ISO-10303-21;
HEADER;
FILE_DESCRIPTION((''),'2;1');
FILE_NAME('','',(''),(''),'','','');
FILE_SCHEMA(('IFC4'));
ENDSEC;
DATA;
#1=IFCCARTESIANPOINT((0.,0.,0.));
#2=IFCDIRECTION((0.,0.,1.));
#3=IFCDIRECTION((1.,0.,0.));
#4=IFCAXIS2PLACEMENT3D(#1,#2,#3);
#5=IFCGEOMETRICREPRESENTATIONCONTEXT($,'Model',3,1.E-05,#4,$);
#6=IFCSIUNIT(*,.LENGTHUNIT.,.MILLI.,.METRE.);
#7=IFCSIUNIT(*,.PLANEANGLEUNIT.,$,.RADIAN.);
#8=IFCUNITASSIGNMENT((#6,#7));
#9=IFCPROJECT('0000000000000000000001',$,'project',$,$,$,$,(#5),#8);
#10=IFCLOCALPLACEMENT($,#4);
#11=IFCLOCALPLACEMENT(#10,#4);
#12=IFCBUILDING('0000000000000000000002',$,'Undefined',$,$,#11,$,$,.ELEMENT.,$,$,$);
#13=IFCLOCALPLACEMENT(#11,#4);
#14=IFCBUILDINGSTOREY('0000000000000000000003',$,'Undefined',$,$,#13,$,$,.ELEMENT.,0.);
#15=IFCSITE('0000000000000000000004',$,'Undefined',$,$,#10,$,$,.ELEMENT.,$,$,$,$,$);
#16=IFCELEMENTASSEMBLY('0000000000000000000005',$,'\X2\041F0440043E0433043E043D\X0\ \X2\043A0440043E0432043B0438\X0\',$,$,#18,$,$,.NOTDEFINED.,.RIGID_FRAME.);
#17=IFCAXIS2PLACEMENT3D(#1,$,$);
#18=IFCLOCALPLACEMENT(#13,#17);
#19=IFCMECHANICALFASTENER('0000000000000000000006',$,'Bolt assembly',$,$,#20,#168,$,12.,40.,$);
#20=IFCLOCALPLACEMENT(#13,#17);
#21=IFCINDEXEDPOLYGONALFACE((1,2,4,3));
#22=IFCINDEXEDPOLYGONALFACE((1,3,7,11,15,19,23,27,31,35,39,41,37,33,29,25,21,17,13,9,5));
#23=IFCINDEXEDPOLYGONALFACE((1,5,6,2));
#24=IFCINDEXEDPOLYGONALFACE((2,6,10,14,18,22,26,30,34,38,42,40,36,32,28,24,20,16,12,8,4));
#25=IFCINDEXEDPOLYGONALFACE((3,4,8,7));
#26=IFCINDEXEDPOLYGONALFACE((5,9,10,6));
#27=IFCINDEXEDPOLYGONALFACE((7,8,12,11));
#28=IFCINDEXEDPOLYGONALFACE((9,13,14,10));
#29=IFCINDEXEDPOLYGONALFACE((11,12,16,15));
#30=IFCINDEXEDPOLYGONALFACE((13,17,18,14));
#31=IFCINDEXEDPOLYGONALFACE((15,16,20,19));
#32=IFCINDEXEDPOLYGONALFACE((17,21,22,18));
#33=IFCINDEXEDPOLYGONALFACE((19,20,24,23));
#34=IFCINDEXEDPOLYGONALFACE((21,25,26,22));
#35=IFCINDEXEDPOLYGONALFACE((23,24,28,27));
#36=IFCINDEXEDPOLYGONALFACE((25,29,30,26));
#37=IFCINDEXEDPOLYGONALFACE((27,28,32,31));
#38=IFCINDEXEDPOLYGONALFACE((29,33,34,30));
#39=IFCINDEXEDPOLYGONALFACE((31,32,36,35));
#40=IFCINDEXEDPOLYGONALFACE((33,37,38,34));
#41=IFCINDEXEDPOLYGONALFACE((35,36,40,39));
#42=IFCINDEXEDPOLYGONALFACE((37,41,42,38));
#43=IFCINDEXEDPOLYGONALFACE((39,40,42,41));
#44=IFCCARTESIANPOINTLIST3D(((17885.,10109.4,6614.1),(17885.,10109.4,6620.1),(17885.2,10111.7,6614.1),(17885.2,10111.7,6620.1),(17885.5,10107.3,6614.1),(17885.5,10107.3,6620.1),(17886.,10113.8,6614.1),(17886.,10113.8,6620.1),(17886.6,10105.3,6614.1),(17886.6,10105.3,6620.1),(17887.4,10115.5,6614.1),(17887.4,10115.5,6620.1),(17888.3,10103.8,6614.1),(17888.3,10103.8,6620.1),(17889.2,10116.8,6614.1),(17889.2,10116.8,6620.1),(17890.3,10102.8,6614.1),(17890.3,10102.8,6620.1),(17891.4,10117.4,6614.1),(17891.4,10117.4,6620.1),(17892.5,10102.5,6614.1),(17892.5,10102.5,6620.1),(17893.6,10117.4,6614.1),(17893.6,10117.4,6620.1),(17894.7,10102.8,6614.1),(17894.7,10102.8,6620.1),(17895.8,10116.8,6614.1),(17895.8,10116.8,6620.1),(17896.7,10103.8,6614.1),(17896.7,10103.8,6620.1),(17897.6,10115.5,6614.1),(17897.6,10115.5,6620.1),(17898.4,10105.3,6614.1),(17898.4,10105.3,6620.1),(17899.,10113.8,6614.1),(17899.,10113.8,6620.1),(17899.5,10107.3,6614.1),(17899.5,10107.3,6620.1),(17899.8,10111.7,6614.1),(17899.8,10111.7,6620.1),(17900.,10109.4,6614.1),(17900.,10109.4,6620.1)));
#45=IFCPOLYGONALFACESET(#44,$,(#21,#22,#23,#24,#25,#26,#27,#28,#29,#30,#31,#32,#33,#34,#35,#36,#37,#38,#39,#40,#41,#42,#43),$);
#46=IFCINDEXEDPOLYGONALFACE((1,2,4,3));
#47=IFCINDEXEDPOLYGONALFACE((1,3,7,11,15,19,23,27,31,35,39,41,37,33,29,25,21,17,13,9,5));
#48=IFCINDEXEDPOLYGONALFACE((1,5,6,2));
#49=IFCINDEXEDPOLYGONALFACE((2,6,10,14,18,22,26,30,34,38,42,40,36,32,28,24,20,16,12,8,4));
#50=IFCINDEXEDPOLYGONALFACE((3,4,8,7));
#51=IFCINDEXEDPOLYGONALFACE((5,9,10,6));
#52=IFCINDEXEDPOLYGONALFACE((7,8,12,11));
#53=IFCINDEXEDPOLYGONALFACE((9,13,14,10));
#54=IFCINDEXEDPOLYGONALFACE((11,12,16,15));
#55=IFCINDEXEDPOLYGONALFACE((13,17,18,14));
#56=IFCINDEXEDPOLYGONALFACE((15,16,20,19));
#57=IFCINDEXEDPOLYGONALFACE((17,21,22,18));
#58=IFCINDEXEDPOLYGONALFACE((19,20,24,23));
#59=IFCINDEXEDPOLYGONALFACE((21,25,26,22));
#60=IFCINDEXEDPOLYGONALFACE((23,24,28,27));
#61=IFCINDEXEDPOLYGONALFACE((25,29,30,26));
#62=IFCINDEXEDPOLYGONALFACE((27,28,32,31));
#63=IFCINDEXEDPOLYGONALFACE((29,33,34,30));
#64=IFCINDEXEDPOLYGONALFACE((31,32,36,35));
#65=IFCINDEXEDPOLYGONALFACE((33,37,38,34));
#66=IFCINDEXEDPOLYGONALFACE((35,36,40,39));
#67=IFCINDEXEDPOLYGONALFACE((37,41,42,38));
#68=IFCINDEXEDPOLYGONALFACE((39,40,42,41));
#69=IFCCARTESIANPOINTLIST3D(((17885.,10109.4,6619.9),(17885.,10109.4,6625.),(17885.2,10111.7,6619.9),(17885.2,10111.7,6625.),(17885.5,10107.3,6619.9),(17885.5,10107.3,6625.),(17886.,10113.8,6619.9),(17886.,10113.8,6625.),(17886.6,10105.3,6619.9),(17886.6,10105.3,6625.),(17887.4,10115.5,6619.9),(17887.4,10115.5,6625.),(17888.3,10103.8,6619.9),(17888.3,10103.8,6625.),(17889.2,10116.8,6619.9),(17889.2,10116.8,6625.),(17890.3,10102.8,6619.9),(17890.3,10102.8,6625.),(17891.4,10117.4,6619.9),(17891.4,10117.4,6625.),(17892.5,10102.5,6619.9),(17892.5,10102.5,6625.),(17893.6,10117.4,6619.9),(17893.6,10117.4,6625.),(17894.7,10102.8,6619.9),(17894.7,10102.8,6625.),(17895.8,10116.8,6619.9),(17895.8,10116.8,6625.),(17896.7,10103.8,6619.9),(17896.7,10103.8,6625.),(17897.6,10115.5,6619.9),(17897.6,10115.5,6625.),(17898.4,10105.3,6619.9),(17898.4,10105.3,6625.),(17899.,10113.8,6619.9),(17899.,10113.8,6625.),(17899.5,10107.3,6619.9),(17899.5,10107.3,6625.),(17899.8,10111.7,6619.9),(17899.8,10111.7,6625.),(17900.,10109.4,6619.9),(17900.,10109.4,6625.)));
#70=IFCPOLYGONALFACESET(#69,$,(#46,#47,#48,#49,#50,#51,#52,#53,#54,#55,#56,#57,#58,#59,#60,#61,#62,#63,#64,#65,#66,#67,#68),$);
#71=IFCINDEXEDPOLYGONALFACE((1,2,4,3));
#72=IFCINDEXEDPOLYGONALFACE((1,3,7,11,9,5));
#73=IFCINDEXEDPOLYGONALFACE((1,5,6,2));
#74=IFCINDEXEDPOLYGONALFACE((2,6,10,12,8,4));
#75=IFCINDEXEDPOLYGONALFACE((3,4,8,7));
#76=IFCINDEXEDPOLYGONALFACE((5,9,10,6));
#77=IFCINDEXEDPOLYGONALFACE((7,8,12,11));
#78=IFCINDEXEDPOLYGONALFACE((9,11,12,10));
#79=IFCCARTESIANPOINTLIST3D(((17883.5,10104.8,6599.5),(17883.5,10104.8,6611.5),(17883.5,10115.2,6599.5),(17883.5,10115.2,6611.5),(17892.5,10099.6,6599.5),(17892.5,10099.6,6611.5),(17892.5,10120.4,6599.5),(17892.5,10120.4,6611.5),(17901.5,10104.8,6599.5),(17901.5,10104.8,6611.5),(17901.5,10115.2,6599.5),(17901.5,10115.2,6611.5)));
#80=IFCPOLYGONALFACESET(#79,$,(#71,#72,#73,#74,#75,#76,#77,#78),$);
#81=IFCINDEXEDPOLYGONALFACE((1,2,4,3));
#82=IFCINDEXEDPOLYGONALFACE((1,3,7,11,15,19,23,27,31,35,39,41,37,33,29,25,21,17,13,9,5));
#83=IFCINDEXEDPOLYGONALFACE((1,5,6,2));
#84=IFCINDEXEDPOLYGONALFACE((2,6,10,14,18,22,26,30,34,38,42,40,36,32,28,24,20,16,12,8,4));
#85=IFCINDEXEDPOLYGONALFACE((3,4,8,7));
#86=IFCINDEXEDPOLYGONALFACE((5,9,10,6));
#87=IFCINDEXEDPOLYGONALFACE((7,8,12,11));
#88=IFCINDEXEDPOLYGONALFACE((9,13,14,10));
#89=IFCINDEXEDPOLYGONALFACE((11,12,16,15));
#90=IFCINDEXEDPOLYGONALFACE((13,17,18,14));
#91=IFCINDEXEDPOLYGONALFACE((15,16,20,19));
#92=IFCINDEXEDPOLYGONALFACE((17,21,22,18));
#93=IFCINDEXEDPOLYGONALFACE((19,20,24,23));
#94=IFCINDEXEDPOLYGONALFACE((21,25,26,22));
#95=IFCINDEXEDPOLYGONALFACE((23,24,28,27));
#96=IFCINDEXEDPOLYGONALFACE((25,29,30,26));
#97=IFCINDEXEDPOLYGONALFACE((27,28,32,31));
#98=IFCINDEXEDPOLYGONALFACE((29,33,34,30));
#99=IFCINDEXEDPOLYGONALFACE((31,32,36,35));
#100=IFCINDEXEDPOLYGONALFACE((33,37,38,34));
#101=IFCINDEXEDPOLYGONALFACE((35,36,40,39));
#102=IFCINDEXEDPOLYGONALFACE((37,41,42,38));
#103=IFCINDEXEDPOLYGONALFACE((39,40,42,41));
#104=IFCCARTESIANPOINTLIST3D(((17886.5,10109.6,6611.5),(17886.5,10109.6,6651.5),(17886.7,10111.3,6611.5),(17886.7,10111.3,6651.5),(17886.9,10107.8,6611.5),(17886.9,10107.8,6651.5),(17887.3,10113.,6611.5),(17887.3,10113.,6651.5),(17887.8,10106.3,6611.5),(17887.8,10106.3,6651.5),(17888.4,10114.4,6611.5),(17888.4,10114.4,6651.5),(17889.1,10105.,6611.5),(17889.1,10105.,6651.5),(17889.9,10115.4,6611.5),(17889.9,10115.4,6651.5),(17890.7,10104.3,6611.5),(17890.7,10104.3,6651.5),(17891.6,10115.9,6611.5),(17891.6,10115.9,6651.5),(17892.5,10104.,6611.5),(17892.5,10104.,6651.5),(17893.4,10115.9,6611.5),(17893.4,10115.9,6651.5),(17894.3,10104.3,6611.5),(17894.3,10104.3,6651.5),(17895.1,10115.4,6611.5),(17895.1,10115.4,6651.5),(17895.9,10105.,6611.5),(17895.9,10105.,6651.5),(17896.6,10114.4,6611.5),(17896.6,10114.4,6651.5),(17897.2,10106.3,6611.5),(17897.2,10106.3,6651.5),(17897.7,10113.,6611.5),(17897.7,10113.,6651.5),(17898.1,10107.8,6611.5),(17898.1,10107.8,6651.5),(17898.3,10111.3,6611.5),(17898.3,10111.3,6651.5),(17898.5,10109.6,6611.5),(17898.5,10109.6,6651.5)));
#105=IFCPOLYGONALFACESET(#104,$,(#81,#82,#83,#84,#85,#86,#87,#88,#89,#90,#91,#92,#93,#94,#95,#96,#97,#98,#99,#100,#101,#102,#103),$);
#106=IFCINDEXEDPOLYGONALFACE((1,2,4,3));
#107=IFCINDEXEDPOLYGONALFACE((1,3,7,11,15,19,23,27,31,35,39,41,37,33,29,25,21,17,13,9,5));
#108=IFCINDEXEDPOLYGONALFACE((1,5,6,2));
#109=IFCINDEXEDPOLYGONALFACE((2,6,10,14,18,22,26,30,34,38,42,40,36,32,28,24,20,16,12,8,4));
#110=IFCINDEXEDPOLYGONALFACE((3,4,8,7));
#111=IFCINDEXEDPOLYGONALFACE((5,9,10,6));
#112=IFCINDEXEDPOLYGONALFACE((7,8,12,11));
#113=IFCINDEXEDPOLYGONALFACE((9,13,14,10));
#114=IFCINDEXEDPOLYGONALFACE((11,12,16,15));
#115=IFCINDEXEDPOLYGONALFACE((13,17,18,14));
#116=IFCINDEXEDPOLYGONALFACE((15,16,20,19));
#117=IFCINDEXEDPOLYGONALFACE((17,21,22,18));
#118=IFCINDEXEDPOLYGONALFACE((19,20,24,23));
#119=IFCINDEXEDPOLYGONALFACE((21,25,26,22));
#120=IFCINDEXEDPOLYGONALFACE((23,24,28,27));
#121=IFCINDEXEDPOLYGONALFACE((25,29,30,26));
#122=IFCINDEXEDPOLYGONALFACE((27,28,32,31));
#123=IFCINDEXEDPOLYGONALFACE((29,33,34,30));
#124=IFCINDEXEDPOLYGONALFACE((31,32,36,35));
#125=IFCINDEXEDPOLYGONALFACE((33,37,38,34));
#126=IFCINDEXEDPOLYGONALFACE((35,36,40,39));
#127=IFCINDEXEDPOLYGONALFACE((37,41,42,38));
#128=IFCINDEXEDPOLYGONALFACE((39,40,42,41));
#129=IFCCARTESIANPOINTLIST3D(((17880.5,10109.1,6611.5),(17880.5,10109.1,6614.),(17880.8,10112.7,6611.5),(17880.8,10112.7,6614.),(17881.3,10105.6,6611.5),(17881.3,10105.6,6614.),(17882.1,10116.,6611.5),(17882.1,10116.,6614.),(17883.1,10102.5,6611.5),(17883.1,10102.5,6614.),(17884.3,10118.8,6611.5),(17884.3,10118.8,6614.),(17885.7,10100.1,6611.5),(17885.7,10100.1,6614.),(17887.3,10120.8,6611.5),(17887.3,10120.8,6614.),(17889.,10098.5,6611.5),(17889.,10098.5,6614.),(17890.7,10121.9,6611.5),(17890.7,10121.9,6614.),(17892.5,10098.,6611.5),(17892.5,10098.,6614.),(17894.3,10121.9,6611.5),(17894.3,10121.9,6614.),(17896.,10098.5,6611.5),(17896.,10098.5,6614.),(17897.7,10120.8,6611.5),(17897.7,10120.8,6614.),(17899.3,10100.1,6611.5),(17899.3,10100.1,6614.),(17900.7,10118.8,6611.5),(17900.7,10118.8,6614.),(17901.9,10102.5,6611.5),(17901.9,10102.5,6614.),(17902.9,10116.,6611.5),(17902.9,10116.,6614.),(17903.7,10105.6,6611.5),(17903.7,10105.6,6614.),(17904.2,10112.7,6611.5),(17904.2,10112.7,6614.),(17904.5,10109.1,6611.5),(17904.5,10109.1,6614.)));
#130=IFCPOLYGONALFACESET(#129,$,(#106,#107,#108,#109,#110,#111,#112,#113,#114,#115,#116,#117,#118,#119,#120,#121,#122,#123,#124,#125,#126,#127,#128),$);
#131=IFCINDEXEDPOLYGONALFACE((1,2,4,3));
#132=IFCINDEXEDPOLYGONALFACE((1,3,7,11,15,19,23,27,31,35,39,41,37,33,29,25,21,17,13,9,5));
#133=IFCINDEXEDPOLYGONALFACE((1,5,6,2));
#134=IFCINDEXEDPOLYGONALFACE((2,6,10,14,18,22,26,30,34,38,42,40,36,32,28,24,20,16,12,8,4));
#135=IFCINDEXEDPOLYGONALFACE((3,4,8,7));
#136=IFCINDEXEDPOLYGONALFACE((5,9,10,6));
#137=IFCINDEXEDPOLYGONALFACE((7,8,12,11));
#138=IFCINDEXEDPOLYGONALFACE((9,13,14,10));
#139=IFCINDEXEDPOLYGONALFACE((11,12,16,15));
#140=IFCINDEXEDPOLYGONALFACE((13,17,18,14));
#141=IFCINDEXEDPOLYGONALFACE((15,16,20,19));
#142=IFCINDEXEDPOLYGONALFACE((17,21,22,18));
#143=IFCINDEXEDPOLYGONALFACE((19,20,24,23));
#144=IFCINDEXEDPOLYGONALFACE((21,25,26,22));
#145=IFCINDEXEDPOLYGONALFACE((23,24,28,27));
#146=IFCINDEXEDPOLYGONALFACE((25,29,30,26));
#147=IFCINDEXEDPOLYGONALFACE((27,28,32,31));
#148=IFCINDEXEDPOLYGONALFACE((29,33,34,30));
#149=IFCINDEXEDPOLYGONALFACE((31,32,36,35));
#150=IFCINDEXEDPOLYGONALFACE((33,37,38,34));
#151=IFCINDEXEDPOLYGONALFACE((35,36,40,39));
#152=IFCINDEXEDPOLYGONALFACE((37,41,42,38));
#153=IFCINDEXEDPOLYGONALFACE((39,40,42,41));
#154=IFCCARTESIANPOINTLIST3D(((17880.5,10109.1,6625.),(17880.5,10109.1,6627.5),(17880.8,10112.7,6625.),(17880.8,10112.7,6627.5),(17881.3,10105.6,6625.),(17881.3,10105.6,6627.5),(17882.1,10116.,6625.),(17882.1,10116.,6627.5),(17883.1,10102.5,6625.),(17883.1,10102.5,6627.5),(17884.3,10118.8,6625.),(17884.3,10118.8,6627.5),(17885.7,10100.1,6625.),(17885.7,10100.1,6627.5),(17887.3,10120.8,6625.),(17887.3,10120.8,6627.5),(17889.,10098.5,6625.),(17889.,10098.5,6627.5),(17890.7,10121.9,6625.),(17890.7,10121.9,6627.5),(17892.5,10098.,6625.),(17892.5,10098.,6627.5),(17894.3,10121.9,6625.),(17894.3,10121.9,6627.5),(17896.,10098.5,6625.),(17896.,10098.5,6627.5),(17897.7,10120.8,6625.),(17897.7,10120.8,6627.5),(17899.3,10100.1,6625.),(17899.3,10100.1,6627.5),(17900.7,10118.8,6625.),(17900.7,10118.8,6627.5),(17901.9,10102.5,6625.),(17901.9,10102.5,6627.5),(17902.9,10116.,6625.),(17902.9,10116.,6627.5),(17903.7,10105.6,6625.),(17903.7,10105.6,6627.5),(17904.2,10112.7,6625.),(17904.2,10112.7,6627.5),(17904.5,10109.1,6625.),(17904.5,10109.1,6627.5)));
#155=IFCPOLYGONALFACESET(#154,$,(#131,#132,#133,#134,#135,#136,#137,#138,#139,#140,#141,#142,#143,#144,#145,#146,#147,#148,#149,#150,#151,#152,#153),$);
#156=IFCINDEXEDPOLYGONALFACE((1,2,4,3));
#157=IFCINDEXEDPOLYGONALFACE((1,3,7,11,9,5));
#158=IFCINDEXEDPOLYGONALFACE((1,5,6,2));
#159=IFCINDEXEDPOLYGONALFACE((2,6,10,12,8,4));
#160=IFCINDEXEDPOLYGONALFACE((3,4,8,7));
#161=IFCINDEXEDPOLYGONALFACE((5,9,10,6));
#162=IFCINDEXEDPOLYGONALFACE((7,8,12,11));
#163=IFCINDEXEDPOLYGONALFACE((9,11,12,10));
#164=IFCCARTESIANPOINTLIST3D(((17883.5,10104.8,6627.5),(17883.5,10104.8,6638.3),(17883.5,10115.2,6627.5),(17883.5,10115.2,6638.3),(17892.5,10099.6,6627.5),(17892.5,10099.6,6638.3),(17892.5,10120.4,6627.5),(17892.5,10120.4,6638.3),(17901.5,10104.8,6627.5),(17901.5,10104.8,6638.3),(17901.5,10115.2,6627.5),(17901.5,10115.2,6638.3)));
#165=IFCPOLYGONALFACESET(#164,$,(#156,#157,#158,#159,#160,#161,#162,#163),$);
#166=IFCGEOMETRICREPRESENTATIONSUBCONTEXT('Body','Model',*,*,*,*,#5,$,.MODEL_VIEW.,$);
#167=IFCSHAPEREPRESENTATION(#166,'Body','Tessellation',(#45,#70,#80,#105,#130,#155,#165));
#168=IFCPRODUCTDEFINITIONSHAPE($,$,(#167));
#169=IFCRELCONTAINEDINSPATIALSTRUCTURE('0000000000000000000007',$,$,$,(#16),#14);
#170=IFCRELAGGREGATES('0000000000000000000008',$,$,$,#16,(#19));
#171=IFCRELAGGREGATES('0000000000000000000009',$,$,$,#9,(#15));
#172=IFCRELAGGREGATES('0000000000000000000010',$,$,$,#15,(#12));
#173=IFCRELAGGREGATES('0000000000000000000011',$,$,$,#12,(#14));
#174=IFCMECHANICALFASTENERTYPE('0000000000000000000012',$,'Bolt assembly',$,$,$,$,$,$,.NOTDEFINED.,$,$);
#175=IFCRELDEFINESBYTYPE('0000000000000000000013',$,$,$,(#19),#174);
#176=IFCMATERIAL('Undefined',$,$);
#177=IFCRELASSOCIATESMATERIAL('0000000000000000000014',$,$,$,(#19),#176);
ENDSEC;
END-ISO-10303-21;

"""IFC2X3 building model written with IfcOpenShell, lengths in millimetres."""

from ifc_helpers import new_model, si_unit, frame, origin_with_axes, origin_2d_with_axis, place, context, subcontext, project, spatial, polyline, circle, outline, extrude, source, transform, mapped, material, type_object, element, aggregate, save


model = new_model("IFC2X3")

# Units and contexts
model_context = context("Model", 3, precision=1e-05, world=origin_with_axes())
body_context = subcontext(model_context, "Body", "Model", "MODEL_VIEW")
ifc_project = project(units=[si_unit("LENGTHUNIT", "METRE", prefix="MILLI"), si_unit("PLANEANGLEUNIT", "RADIAN")], contexts=[model_context])

# Site, building, storey
site_placement = place(None, origin_with_axes())
site = spatial("IfcSite", under=ifc_project, at=site_placement, Name="Undefined", CompositionType="ELEMENT")
building_placement = place(site_placement, origin_with_axes())
building = spatial("IfcBuilding", under=site, at=building_placement, Name="Undefined", CompositionType="ELEMENT")
storey_placement = place(building_placement, origin_with_axes())
storey = spatial("IfcBuildingStorey", under=building, at=storey_placement, Name="Undefined", CompositionType="ELEMENT", Elevation=0.0)

# Element assembly
assembly_1_placement = place(storey_placement, origin_with_axes())
assembly_1 = element("IfcElementAssembly", 1, at=assembly_1_placement, inside=storey, Name="Прогон кровли", AssemblyPlace="NOTDEFINED", PredefinedType="RIGID_FRAME")

# Mechanical fastener
ifc_material_1 = material(Name="Undefined")
mechanical_fastener_type = type_object("IfcMechanicalFastenerType", Name="Bolt assembly")
shared_shape_1 = source(origin_with_axes(), body_context, "Body", "SweptSolid", [
    extrude(circle(Radius=7.5, at=origin_2d_with_axis()), frame((0.0, -5.9, 0.0), z_axis=(0.0, 1.0, 0.0), x_axis=(1.0, 0.0, 0.0)), (0.0, 0.0, 1.0), 6.0),
    extrude(circle(Radius=7.5, at=origin_2d_with_axis()), frame((0.0, -0.1, 0.0), z_axis=(0.0, 1.0, 0.0), x_axis=(1.0, 0.0, 0.0)), (0.0, 0.0, 1.0), 5.1),
    extrude(outline(polyline([(10.4, 0.0), (5.2, 9.0), (-5.2, 9.0), (-10.4, 0.0), (-5.2, -9.0), (5.2, -9.0), (10.4, 0.0)])), frame((0.0, -20.5, 0.0), z_axis=(0.0, 1.0, 0.0), x_axis=(1.0, 0.0, 0.0)), (0.0, 0.0, 1.0), 12.0),
    extrude(circle(Radius=6.0, at=origin_2d_with_axis()), frame((0.0, -8.5, 0.0), z_axis=(0.0, 1.0, 0.0), x_axis=(1.0, 0.0, 0.0)), (0.0, 0.0, 1.0), 40.0),
    extrude(circle(Radius=12.0, at=origin_2d_with_axis()), frame((0.0, -8.5, 0.0), z_axis=(0.0, 1.0, 0.0), x_axis=(1.0, 0.0, 0.0)), (0.0, 0.0, 1.0), 2.5),
    extrude(circle(Radius=12.0, at=origin_2d_with_axis()), frame((0.0, 5.0, 0.0), z_axis=(0.0, 1.0, 0.0), x_axis=(1.0, 0.0, 0.0)), (0.0, 0.0, 1.0), 2.5),
    extrude(outline(polyline([(10.4, 0.0), (5.2, 9.0), (-5.2, 9.0), (-10.4, 0.0), (-5.2, -9.0), (5.2, -9.0), (10.4, 0.0)])), frame((0.0, 7.5, 0.0), z_axis=(0.0, 1.0, 0.0), x_axis=(1.0, 0.0, 0.0)), (0.0, 0.0, 1.0), 10.8),
])
mechanical_fastener_1_placement = place(assembly_1_placement, frame((17892.5, 10110.0, 6620.0), z_axis=(-1.0, 0.0, 0.0), x_axis=(0.0, -1.0, 0.0)))
mechanical_fastener_1 = element("IfcMechanicalFastener", 2, at=mechanical_fastener_1_placement, type_object=mechanical_fastener_type, material=ifc_material_1, Name="Bolt assembly", NominalDiameter=12.0, NominalLength=40.0, context=body_context, shape_type="MappedRepresentation", body=[
    mapped(shared_shape_1, transform((0.0, 0.0, 0.0))),
])
aggregate(assembly_1, [mechanical_fastener_1])

save(model, "model.ifc")
